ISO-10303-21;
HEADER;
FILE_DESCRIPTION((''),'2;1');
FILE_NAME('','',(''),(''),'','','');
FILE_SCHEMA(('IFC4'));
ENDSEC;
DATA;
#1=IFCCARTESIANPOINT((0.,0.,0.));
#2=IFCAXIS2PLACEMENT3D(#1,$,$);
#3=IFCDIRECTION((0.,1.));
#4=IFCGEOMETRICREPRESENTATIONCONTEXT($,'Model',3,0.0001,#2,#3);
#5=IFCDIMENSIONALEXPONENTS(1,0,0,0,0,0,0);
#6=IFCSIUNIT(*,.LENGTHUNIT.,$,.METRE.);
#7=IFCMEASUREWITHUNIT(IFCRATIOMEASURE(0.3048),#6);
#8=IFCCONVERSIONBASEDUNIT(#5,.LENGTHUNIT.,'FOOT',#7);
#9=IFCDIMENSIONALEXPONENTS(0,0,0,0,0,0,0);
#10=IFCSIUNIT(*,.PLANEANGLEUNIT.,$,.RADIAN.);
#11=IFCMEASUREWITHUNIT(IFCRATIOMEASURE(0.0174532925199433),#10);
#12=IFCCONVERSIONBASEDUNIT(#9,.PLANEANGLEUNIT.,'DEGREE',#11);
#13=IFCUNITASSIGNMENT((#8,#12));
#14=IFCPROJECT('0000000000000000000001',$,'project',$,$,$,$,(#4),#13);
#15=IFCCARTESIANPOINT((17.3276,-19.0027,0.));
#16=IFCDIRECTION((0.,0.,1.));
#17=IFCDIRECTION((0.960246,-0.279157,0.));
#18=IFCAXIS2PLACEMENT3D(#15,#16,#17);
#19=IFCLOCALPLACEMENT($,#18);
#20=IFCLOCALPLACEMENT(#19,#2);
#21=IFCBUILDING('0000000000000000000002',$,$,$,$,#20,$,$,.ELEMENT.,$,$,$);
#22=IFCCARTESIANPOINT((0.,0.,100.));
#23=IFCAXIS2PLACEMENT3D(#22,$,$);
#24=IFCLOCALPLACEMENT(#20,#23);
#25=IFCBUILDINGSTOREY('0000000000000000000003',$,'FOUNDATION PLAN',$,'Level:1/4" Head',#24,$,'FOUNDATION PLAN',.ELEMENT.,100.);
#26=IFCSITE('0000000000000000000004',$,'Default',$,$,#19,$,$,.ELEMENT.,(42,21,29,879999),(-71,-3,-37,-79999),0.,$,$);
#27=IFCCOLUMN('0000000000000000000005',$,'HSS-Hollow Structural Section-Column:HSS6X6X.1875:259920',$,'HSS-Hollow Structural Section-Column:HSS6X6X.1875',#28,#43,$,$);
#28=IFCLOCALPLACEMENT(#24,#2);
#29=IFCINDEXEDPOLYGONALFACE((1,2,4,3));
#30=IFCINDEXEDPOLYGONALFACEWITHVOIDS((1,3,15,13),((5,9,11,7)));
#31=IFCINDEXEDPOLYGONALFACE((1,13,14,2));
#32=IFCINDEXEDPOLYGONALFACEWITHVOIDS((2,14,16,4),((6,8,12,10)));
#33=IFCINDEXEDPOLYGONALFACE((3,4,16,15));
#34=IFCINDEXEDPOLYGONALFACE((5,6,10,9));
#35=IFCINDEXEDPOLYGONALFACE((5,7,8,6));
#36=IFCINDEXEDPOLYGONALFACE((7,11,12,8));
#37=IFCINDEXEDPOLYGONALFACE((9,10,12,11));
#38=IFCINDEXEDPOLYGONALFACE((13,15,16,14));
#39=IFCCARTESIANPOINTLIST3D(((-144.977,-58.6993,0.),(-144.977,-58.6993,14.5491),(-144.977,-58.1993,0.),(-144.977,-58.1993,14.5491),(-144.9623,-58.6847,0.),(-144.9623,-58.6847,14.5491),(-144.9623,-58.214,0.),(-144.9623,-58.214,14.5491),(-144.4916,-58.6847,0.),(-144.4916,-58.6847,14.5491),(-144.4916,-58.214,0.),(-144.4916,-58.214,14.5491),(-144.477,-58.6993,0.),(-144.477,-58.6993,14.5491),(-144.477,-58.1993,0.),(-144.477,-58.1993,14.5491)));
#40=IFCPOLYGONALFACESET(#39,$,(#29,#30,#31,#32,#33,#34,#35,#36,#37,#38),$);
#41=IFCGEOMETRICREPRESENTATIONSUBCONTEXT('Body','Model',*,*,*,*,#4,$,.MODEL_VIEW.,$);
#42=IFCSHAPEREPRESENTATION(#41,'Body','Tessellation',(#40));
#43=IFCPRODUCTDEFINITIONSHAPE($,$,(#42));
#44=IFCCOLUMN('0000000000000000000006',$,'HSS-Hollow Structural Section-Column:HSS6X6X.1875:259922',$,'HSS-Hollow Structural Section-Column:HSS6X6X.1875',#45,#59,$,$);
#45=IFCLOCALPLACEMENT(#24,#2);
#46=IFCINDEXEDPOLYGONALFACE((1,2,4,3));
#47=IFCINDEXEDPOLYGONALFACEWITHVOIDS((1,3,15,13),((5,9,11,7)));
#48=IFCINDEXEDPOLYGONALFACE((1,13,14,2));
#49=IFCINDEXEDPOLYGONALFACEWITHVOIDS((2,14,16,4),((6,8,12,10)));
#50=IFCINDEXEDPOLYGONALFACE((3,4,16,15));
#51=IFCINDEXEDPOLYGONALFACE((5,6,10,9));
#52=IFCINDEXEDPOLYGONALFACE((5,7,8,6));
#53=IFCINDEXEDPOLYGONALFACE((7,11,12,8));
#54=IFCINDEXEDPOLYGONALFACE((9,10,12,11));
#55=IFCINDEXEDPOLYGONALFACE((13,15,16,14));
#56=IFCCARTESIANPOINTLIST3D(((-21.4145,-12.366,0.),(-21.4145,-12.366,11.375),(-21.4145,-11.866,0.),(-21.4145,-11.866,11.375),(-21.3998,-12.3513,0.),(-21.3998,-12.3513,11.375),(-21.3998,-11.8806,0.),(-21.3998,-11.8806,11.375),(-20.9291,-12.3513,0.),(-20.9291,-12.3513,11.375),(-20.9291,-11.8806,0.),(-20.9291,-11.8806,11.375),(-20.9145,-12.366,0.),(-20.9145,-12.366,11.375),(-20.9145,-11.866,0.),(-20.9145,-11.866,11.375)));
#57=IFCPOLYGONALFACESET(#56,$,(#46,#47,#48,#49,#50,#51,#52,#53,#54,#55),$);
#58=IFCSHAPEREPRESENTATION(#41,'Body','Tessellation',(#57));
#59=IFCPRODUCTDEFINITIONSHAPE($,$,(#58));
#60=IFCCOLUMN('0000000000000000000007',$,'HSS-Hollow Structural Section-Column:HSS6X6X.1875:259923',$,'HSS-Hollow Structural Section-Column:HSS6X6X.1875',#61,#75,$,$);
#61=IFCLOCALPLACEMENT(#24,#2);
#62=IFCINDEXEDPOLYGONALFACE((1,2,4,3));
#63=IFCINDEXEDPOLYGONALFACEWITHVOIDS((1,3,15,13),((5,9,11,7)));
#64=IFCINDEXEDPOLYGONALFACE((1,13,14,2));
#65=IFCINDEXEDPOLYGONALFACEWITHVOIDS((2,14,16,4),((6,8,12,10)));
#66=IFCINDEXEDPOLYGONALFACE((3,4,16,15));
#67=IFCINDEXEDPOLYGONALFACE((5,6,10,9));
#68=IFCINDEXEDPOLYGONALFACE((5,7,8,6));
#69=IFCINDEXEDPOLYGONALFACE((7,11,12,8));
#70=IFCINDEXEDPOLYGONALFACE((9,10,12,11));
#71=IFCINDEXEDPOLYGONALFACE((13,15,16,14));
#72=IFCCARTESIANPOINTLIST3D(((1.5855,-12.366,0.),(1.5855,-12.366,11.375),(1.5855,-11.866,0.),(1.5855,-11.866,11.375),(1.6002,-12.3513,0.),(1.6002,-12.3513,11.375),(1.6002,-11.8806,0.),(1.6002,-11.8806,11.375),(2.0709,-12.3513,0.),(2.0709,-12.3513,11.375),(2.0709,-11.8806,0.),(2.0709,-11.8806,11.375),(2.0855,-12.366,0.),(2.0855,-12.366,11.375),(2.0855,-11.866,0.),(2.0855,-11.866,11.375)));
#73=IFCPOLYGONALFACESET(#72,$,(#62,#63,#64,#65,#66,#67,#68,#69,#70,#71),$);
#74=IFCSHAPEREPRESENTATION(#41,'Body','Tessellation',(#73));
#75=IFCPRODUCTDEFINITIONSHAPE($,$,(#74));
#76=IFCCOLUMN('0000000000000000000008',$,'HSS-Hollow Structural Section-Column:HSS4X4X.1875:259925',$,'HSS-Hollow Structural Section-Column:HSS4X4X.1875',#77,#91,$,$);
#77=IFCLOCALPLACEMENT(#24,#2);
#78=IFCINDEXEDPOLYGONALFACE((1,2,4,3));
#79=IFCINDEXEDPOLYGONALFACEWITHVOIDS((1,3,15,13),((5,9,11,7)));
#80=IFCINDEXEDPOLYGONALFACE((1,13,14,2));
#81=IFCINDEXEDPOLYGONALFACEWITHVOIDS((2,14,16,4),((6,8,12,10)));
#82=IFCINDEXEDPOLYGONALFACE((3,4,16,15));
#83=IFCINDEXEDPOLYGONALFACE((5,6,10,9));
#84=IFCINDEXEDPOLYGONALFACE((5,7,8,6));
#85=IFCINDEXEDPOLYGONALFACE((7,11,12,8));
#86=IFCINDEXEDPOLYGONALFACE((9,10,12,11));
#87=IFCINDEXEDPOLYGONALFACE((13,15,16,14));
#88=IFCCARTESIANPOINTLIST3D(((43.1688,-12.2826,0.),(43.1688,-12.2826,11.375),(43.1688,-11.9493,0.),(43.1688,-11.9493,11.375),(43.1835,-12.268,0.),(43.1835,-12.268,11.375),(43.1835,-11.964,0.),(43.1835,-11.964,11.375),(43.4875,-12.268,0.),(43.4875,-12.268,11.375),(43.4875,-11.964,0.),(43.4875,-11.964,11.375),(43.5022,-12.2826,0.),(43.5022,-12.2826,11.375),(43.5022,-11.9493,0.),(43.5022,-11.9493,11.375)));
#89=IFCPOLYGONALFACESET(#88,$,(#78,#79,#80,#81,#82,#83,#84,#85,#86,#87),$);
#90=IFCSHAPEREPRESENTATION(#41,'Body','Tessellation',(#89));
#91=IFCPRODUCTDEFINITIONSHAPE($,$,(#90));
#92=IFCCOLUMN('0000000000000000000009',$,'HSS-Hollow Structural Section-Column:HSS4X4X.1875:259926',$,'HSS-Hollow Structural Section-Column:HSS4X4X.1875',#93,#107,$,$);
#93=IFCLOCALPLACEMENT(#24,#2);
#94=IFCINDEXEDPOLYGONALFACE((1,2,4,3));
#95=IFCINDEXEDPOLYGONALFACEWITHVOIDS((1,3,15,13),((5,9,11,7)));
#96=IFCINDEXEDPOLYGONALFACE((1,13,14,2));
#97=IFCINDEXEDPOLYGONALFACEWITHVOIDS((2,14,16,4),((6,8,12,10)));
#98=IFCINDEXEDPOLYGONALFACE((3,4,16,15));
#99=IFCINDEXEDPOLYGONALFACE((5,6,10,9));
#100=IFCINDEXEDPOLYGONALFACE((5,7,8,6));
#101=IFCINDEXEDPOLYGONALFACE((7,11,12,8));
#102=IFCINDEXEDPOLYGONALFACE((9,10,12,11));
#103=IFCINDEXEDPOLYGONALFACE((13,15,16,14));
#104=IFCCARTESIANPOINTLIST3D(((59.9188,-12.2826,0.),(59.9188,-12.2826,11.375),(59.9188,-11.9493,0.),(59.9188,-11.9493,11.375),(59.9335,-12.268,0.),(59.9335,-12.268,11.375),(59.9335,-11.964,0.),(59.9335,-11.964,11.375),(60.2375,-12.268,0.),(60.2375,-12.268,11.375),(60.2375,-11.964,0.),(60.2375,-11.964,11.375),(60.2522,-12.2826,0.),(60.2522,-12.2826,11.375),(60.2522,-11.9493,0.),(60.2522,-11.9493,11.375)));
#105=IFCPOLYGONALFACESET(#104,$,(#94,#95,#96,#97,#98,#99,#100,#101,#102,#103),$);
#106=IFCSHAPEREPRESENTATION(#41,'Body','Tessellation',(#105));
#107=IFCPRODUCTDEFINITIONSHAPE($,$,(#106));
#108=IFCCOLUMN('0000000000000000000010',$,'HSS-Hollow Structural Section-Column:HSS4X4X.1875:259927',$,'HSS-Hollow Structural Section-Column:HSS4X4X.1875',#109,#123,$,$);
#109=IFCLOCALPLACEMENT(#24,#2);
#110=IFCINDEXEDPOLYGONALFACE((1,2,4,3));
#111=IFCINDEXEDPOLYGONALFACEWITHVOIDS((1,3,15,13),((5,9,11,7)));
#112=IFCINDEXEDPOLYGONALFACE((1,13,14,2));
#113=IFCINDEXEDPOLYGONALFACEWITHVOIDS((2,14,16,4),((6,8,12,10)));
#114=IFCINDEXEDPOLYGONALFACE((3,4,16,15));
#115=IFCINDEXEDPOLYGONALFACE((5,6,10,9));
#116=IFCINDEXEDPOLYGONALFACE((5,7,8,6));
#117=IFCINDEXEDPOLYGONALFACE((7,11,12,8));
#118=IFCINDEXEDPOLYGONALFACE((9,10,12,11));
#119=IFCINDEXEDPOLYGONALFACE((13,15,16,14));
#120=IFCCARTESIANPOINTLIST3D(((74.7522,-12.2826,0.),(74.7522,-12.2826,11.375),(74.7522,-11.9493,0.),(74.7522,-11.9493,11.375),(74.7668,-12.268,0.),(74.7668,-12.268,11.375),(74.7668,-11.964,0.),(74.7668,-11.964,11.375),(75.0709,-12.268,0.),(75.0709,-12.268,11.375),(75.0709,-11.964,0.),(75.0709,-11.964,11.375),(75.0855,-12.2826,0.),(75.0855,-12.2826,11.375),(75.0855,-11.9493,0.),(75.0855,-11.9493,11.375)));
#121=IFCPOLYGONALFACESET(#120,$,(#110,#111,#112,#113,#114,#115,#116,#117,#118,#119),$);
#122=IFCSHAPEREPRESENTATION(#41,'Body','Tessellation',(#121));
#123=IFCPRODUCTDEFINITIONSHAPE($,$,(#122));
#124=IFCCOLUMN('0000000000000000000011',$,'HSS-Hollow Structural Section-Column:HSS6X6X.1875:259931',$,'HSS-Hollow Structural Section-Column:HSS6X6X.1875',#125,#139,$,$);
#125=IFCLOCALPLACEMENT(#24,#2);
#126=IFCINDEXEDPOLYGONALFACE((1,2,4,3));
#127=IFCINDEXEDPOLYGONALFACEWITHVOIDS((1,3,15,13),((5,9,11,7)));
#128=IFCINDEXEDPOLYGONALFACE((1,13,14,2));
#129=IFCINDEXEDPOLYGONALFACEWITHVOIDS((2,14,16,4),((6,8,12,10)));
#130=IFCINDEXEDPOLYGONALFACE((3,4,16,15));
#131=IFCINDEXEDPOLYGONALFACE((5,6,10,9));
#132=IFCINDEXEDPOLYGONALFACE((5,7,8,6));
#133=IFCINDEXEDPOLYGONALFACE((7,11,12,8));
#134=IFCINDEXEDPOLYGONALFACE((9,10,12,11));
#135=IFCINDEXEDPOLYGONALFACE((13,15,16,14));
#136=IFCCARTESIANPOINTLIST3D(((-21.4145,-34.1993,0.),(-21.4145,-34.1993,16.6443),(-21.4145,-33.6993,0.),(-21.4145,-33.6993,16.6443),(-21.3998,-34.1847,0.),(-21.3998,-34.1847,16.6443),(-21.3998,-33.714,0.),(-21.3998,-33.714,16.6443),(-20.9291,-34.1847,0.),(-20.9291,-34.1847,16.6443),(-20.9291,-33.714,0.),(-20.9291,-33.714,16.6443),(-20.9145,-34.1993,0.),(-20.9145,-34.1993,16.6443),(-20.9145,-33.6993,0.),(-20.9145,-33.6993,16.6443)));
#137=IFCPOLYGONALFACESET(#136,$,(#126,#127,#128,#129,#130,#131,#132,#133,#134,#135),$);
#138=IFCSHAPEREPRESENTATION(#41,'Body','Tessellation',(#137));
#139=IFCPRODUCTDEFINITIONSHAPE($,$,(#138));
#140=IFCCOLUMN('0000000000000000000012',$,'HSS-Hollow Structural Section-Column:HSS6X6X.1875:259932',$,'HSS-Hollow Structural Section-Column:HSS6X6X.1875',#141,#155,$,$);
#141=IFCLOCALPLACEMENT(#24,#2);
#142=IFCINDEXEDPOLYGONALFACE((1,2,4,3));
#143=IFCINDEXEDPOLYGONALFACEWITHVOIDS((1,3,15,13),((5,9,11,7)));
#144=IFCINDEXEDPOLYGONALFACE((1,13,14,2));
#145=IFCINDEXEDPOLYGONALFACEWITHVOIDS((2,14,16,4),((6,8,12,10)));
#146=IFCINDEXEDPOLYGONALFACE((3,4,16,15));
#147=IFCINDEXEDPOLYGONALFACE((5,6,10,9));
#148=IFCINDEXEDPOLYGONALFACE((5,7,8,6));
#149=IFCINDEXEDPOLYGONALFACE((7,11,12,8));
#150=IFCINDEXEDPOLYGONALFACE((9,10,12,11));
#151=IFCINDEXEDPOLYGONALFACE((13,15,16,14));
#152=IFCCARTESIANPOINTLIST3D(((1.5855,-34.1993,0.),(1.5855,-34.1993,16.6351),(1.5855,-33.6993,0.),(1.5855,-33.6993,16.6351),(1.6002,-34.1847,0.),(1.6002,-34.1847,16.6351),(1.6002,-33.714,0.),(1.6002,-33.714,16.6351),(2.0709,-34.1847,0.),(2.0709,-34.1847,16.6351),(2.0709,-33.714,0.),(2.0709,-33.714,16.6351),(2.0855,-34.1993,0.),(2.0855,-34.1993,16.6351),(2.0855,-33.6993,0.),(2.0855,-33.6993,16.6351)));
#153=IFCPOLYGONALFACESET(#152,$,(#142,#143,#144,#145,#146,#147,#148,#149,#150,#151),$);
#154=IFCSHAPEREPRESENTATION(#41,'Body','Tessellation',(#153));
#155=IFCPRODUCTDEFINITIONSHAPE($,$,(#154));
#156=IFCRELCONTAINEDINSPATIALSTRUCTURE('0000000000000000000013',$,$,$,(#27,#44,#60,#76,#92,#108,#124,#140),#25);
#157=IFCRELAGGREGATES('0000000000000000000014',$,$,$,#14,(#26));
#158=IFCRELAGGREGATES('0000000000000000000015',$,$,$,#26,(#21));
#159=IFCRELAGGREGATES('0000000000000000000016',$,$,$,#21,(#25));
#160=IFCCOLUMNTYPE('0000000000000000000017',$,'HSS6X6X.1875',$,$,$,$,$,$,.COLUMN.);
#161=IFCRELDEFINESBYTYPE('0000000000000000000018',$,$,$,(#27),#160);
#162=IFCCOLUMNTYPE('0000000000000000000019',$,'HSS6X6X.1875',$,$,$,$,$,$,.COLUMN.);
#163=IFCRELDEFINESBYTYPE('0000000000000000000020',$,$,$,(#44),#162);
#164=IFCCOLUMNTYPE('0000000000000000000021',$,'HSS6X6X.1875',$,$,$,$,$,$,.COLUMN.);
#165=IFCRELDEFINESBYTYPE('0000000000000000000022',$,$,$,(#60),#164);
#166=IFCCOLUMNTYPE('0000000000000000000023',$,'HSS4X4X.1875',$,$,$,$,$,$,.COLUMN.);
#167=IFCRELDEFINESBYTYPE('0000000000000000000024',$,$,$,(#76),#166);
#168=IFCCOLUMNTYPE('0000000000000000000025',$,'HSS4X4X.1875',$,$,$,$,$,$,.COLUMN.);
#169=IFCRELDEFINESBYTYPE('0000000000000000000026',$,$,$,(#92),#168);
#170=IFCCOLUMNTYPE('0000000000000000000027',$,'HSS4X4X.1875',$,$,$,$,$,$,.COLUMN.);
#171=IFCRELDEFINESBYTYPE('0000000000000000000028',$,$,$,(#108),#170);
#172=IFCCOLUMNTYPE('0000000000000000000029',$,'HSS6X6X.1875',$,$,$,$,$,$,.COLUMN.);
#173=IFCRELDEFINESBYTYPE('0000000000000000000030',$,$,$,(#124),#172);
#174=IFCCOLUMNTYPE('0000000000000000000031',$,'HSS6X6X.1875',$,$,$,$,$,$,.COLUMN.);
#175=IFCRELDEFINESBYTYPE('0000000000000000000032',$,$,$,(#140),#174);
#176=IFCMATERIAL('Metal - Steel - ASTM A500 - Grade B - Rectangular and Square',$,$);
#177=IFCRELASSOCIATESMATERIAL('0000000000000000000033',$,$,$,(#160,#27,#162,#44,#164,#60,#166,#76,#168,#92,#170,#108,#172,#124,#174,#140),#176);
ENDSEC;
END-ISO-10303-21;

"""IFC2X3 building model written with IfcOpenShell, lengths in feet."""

from ifc_helpers import new_model, entity, si_unit, converted_unit, direction, frame, frame_2d, origin, origin_2d_with_axis, place, context, subcontext, project, spatial, rectangle, extrude, boolean, source, transform, mapped, material, type_object, type_shapes, element, save


model = new_model("IFC2X3")

# Units and contexts
model_context = context("Model", 3, precision=0.0001, world=origin(), true_north=direction((0.0, 1.0)))
body_context = subcontext(model_context, "Body", "Model", "MODEL_VIEW")
ifc_project = project(units=[converted_unit("LENGTHUNIT", "FOOT", entity("IfcRatioMeasure", 0.3048), si_unit("LENGTHUNIT", "METRE"), dimensions=[1, 0, 0, 0, 0, 0, 0]), converted_unit("PLANEANGLEUNIT", "DEGREE", entity("IfcRatioMeasure", 0.0174532925199433), si_unit("PLANEANGLEUNIT", "RADIAN"), dimensions=[0, 0, 0, 0, 0, 0, 0])], contexts=[model_context])

# Site, building, storey
site_placement = place(None, frame((17.3276, -19.0027, 0.0), z_axis=(0.0, 0.0, 1.0), x_axis=(0.960246, -0.279157, 0.0)))
site = spatial("IfcSite", under=ifc_project, at=site_placement, Name="Default", CompositionType="ELEMENT", RefLatitude=(42, 21, 29, 879999), RefLongitude=(-71, -3, -37, -79999), RefElevation=0.0)
building_placement = place(site_placement, origin())
building = spatial("IfcBuilding", under=site, at=building_placement, CompositionType="ELEMENT")
storey_placement = place(building_placement, frame((0.0, 0.0, 100.0)))
storey = spatial("IfcBuildingStorey", under=building, at=storey_placement, Name="FOUNDATION PLAN", ObjectType="Level:1/4\" Head", LongName="FOUNDATION PLAN", CompositionType="ELEMENT", Elevation=100.0)

# Columns
ifc_material_1 = material(Name="Metal - Steel - ASTM A500 - Grade B - Rectangular and Square")
column_type_1 = type_object("IfcColumnType", Name="HSS6X6X.1875", PredefinedType="COLUMN", material=ifc_material_1)
shared_shape_1 = source(origin(), body_context, "Body", "SweptSolid", [
    boolean("DIFFERENCE", extrude(rectangle(XDim=0.5, YDim=0.5, at=origin_2d_with_axis()), frame((-144.727, -58.4493, 100.0), z_axis=(0.0, 0.0, 1.0), x_axis=(0.0, -1.0, 0.0)), (0.0, 0.0, 1.0), 14.5491), extrude(rectangle(XDim=0.4707, YDim=0.4707, at=origin_2d_with_axis()), frame((-144.727, -58.4493, 114.5491), z_axis=(0.0, 0.0, -1.0), x_axis=(0.0, -1.0, 0.0)), (0.0, 0.0, 1.0), 14.5491)),
])
type_shapes(column_type_1, [shared_shape_1])
column_1_placement = place(storey_placement, frame((0.0, 0.0, -100.0)))
element("IfcColumn", 1, at=column_1_placement, inside=storey, type_object=column_type_1, material=ifc_material_1, Name="HSS-Hollow Structural Section-Column:HSS6X6X.1875:259920", ObjectType="HSS-Hollow Structural Section-Column:HSS6X6X.1875", context=body_context, shape_type="MappedRepresentation", body=[
    mapped(shared_shape_1, transform((0.0, 0.0, 0.0), scale=1.0)),
])
column_type_2 = type_object("IfcColumnType", Name="HSS6X6X.1875", PredefinedType="COLUMN", material=ifc_material_1)
shared_shape_2 = source(origin(), body_context, "Body", "SweptSolid", [
    boolean("DIFFERENCE", extrude(rectangle(XDim=0.5, YDim=0.5, at=origin_2d_with_axis()), frame((-21.1645, -12.116, 100.0), z_axis=(0.0, 0.0, 1.0), x_axis=(0.0, -1.0, 0.0)), (0.0, 0.0, 1.0), 11.375), extrude(rectangle(XDim=0.4707, YDim=0.4707, at=origin_2d_with_axis()), frame((-21.1645, -12.116, 111.375), z_axis=(0.0, 0.0, -1.0), x_axis=(0.0, -1.0, 0.0)), (0.0, 0.0, 1.0), 11.375)),
])
type_shapes(column_type_2, [shared_shape_2])
column_2_placement = place(storey_placement, frame((0.0, 0.0, -100.0)))
element("IfcColumn", 2, at=column_2_placement, inside=storey, type_object=column_type_2, material=ifc_material_1, Name="HSS-Hollow Structural Section-Column:HSS6X6X.1875:259922", ObjectType="HSS-Hollow Structural Section-Column:HSS6X6X.1875", context=body_context, shape_type="MappedRepresentation", body=[
    mapped(shared_shape_2, transform((0.0, 0.0, 0.0), scale=1.0)),
])
column_type_3 = type_object("IfcColumnType", Name="HSS6X6X.1875", PredefinedType="COLUMN", material=ifc_material_1)
shared_shape_3 = source(origin(), body_context, "Body", "SweptSolid", [
    boolean("DIFFERENCE", extrude(rectangle(XDim=0.5, YDim=0.5, at=origin_2d_with_axis()), frame((1.8355, -12.116, 100.0), z_axis=(0.0, 0.0, 1.0), x_axis=(0.0, -1.0, 0.0)), (0.0, 0.0, 1.0), 11.375), extrude(rectangle(XDim=0.4707, YDim=0.4707, at=origin_2d_with_axis()), frame((1.8355, -12.116, 111.375), z_axis=(0.0, 0.0, -1.0), x_axis=(0.0, -1.0, 0.0)), (0.0, 0.0, 1.0), 11.375)),
])
type_shapes(column_type_3, [shared_shape_3])
column_3_placement = place(storey_placement, frame((0.0, 0.0, -100.0)))
element("IfcColumn", 3, at=column_3_placement, inside=storey, type_object=column_type_3, material=ifc_material_1, Name="HSS-Hollow Structural Section-Column:HSS6X6X.1875:259923", ObjectType="HSS-Hollow Structural Section-Column:HSS6X6X.1875", context=body_context, shape_type="MappedRepresentation", body=[
    mapped(shared_shape_3, transform((0.0, 0.0, 0.0), scale=1.0)),
])
column_type_4 = type_object("IfcColumnType", Name="HSS4X4X.1875", PredefinedType="COLUMN", material=ifc_material_1)
shared_shape_4 = source(origin(), body_context, "Body", "SweptSolid", [
    boolean("DIFFERENCE", extrude(rectangle(XDim=0.3333, YDim=0.3333, at=origin_2d_with_axis()), frame((43.3355, -12.116, 100.0), z_axis=(0.0, 0.0, 1.0), x_axis=(0.0, -1.0, 0.0)), (0.0, 0.0, 1.0), 11.375), extrude(rectangle(XDim=0.304, YDim=0.304, at=frame_2d((0.0, 0.0), x_axis=(1.0, 0.0))), frame((43.3355, -12.116, 111.375), z_axis=(0.0, 0.0, -1.0), x_axis=(0.0, -1.0, 0.0)), (0.0, 0.0, 1.0), 11.375)),
])
type_shapes(column_type_4, [shared_shape_4])
column_4_placement = place(storey_placement, frame((0.0, 0.0, -100.0)))
element("IfcColumn", 4, at=column_4_placement, inside=storey, type_object=column_type_4, material=ifc_material_1, Name="HSS-Hollow Structural Section-Column:HSS4X4X.1875:259925", ObjectType="HSS-Hollow Structural Section-Column:HSS4X4X.1875", context=body_context, shape_type="MappedRepresentation", body=[
    mapped(shared_shape_4, transform((0.0, 0.0, 0.0), scale=1.0)),
])
column_type_5 = type_object("IfcColumnType", Name="HSS4X4X.1875", PredefinedType="COLUMN", material=ifc_material_1)
shared_shape_5 = source(origin(), body_context, "Body", "SweptSolid", [
    boolean("DIFFERENCE", extrude(rectangle(XDim=0.3333, YDim=0.3333, at=frame_2d((0.0, 0.0), x_axis=(1.0, 0.0))), frame((60.0855, -12.116, 100.0), z_axis=(0.0, 0.0, 1.0), x_axis=(0.0, -1.0, 0.0)), (0.0, 0.0, 1.0), 11.375), extrude(rectangle(XDim=0.304, YDim=0.304, at=frame_2d((0.0, 0.0), x_axis=(1.0, 0.0))), frame((60.0855, -12.116, 111.375), z_axis=(0.0, 0.0, -1.0), x_axis=(0.0, -1.0, 0.0)), (0.0, 0.0, 1.0), 11.375)),
])
type_shapes(column_type_5, [shared_shape_5])
column_5_placement = place(storey_placement, frame((0.0, 0.0, -100.0)))
element("IfcColumn", 5, at=column_5_placement, inside=storey, type_object=column_type_5, material=ifc_material_1, Name="HSS-Hollow Structural Section-Column:HSS4X4X.1875:259926", ObjectType="HSS-Hollow Structural Section-Column:HSS4X4X.1875", context=body_context, shape_type="MappedRepresentation", body=[
    mapped(shared_shape_5, transform((0.0, 0.0, 0.0), scale=1.0)),
])
column_type_6 = type_object("IfcColumnType", Name="HSS4X4X.1875", PredefinedType="COLUMN", material=ifc_material_1)
shared_shape_6 = source(origin(), body_context, "Body", "SweptSolid", [
    boolean("DIFFERENCE", extrude(rectangle(XDim=0.3333, YDim=0.3333, at=origin_2d_with_axis()), frame((74.9188, -12.116, 100.0), z_axis=(0.0, 0.0, 1.0), x_axis=(0.0, -1.0, 0.0)), (0.0, 0.0, 1.0), 11.375), extrude(rectangle(XDim=0.304, YDim=0.304, at=frame_2d((0.0, 0.0), x_axis=(1.0, 0.0))), frame((74.9188, -12.116, 111.375), z_axis=(0.0, 0.0, -1.0), x_axis=(0.0, -1.0, 0.0)), (0.0, 0.0, 1.0), 11.375)),
])
type_shapes(column_type_6, [shared_shape_6])
column_6_placement = place(storey_placement, frame((0.0, 0.0, -100.0)))
element("IfcColumn", 6, at=column_6_placement, inside=storey, type_object=column_type_6, material=ifc_material_1, Name="HSS-Hollow Structural Section-Column:HSS4X4X.1875:259927", ObjectType="HSS-Hollow Structural Section-Column:HSS4X4X.1875", context=body_context, shape_type="MappedRepresentation", body=[
    mapped(shared_shape_6, transform((0.0, 0.0, 0.0), scale=1.0)),
])
column_type_7 = type_object("IfcColumnType", Name="HSS6X6X.1875", PredefinedType="COLUMN", material=ifc_material_1)
shared_shape_7 = source(origin(), body_context, "Body", "SweptSolid", [
    boolean("DIFFERENCE", extrude(rectangle(XDim=0.5, YDim=0.5, at=origin_2d_with_axis()), frame((-21.1645, -33.9493, 100.0), z_axis=(0.0, 0.0, 1.0), x_axis=(0.0, -1.0, 0.0)), (0.0, 0.0, 1.0), 16.6443), extrude(rectangle(XDim=0.4707, YDim=0.4707, at=origin_2d_with_axis()), frame((-21.1645, -33.9493, 116.6443), z_axis=(0.0, 0.0, -1.0), x_axis=(0.0, -1.0, 0.0)), (0.0, 0.0, 1.0), 16.6443)),
])
type_shapes(column_type_7, [shared_shape_7])
column_7_placement = place(storey_placement, frame((0.0, 0.0, -100.0)))
element("IfcColumn", 7, at=column_7_placement, inside=storey, type_object=column_type_7, material=ifc_material_1, Name="HSS-Hollow Structural Section-Column:HSS6X6X.1875:259931", ObjectType="HSS-Hollow Structural Section-Column:HSS6X6X.1875", context=body_context, shape_type="MappedRepresentation", body=[
    mapped(shared_shape_7, transform((0.0, 0.0, 0.0), scale=1.0)),
])
column_type_8 = type_object("IfcColumnType", Name="HSS6X6X.1875", PredefinedType="COLUMN", material=ifc_material_1)
shared_shape_8 = source(origin(), body_context, "Body", "SweptSolid", [
    boolean("DIFFERENCE", extrude(rectangle(XDim=0.5, YDim=0.5, at=origin_2d_with_axis()), frame((1.8355, -33.9493, 100.0), z_axis=(0.0, 0.0, 1.0), x_axis=(0.0, -1.0, 0.0)), (0.0, 0.0, 1.0), 16.6351), extrude(rectangle(XDim=0.4707, YDim=0.4707, at=origin_2d_with_axis()), frame((1.8355, -33.9493, 116.6351), z_axis=(0.0, 0.0, -1.0), x_axis=(0.0, -1.0, 0.0)), (0.0, 0.0, 1.0), 16.6351)),
])
type_shapes(column_type_8, [shared_shape_8])
column_8_placement = place(storey_placement, frame((0.0, 0.0, -100.0)))
element("IfcColumn", 8, at=column_8_placement, inside=storey, type_object=column_type_8, material=ifc_material_1, Name="HSS-Hollow Structural Section-Column:HSS6X6X.1875:259932", ObjectType="HSS-Hollow Structural Section-Column:HSS6X6X.1875", context=body_context, shape_type="MappedRepresentation", body=[
    mapped(shared_shape_8, transform((0.0, 0.0, 0.0), scale=1.0)),
])

save(model, "model.ifc")
